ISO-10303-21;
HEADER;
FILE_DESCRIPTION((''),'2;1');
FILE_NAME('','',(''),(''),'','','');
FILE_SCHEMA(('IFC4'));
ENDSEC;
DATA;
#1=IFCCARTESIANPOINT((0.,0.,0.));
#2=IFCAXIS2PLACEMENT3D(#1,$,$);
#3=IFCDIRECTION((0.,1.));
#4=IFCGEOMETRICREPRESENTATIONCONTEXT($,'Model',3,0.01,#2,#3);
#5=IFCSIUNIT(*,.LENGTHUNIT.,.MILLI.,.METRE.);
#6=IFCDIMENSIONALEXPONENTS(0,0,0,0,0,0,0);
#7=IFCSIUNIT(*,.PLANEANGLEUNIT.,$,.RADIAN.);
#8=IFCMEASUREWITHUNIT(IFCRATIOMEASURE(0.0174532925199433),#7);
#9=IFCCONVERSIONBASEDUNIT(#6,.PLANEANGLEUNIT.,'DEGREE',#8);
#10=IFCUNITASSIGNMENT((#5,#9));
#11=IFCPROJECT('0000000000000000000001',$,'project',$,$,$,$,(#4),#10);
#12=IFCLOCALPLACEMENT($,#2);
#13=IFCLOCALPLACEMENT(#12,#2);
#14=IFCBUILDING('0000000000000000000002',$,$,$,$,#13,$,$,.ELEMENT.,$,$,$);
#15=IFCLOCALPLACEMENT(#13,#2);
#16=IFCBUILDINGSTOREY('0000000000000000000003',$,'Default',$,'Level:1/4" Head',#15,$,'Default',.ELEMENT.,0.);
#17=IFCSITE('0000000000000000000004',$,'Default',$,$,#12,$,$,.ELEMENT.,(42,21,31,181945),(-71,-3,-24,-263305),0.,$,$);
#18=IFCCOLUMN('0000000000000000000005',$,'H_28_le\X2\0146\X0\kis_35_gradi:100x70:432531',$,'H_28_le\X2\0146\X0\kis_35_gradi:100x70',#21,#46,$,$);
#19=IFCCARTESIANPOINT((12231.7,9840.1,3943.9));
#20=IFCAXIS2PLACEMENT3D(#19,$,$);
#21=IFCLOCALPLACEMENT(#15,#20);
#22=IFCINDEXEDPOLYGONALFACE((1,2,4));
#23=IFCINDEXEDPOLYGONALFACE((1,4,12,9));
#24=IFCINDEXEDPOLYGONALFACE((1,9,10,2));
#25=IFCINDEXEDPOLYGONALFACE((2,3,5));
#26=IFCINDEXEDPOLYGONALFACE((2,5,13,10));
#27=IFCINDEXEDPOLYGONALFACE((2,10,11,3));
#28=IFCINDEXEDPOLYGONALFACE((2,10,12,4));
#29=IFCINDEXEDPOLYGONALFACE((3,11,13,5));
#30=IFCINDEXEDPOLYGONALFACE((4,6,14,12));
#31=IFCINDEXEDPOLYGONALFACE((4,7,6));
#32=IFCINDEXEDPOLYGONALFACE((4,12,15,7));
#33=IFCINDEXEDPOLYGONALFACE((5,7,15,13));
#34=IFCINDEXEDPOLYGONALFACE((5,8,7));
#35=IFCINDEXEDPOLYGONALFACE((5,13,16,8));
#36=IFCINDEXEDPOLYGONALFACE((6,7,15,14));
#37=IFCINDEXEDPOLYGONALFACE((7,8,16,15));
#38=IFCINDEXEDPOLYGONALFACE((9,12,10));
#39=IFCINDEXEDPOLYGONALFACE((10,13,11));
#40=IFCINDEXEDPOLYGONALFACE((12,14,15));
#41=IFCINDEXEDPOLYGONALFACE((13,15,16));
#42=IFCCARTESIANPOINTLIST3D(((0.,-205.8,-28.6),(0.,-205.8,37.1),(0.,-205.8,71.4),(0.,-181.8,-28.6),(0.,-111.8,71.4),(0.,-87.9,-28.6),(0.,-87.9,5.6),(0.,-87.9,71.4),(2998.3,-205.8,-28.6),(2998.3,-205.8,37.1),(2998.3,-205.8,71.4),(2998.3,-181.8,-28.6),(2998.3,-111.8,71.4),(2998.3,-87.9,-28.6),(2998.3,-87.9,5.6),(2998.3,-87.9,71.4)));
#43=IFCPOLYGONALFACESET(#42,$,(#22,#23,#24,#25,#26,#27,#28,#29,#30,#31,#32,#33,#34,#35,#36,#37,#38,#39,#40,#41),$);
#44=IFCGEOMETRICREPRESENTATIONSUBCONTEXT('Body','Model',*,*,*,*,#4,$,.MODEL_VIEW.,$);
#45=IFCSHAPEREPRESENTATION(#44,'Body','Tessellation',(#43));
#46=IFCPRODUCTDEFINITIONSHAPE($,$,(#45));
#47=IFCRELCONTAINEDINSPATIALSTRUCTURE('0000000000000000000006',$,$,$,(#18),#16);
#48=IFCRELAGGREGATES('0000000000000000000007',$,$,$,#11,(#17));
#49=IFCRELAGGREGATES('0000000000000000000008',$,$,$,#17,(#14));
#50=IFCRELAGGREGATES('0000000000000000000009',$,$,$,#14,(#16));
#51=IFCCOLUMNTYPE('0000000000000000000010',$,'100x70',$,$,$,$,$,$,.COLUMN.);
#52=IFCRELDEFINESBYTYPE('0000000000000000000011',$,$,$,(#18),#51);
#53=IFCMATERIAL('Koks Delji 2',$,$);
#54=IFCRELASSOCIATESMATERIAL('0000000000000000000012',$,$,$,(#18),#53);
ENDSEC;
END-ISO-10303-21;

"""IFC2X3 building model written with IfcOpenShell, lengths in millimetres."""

from ifc_helpers import new_model, entity, si_unit, converted_unit, direction, frame, frame_2d, origin, place, context, subcontext, project, spatial, rectangle, extrude, boolean, source, transform, mapped, material, type_object, type_shapes, element, save


model = new_model("IFC2X3")

# Units and contexts
model_context = context("Model", 3, precision=0.01, world=origin(), true_north=direction((0.0, 1.0)))
body_context = subcontext(model_context, "Body", "Model", "MODEL_VIEW")
ifc_project = project(units=[si_unit("LENGTHUNIT", "METRE", prefix="MILLI"), converted_unit("PLANEANGLEUNIT", "DEGREE", entity("IfcRatioMeasure", 0.0174532925199433), si_unit("PLANEANGLEUNIT", "RADIAN"), dimensions=[0, 0, 0, 0, 0, 0, 0])], contexts=[model_context])

# Site, building, storey
site_placement = place(None, origin())
site = spatial("IfcSite", under=ifc_project, at=site_placement, Name="Default", CompositionType="ELEMENT", RefLatitude=(42, 21, 31, 181945), RefLongitude=(-71, -3, -24, -263305), RefElevation=0.0)
building_placement = place(site_placement, origin())
building = spatial("IfcBuilding", under=site, at=building_placement, CompositionType="ELEMENT")
storey_placement = place(building_placement, origin())
storey = spatial("IfcBuildingStorey", under=building, at=storey_placement, Name="Default", ObjectType="Level:1/4\" Head", LongName="Default", CompositionType="ELEMENT", Elevation=0.0)

# Column
ifc_material_1 = material(Name="Koks Delji 2")
column_type = type_object("IfcColumnType", Name="100x70", PredefinedType="COLUMN")
shared_shape_1 = source(origin(), body_context, "Body", "CSG", [
    boolean("DIFFERENCE", extrude(rectangle(XDim=2998.3, YDim=117.9, at=frame_2d((0.0, 0.0), x_axis=(1.0, 0.0))), frame((1499.1, -146.8, -28.6)), (0.0, 0.0, 1.0), 100.0), extrude(rectangle(XDim=70.0, YDim=100.0, at=frame_2d((0.0, 0.0), x_axis=(0.0, 1.0))), frame((0.0, -146.8, 21.4), z_axis=(-1.0, 0.0, 0.0), x_axis=(0.0, -0.939693, -0.34202)), (0.0, 0.0, -1.0), 2998.3)),
])
type_shapes(column_type, [shared_shape_1])
for number, where, name in (
    (1, (12231.7, 9840.1, 3943.9), "H_28_leņkis_35_gradi:100x70:432531"),
):
    element("IfcColumn", number, at=place(storey_placement, frame(where)), inside=storey, type_object=column_type, material=ifc_material_1, Name=name, ObjectType="H_28_leņkis_35_gradi:100x70", context=body_context, shape_type="MappedRepresentation", body=[
        mapped(shared_shape_1, transform((0.0, 0.0, 0.0), scale=1.0)),
    ])

save(model, "model.ifc")
